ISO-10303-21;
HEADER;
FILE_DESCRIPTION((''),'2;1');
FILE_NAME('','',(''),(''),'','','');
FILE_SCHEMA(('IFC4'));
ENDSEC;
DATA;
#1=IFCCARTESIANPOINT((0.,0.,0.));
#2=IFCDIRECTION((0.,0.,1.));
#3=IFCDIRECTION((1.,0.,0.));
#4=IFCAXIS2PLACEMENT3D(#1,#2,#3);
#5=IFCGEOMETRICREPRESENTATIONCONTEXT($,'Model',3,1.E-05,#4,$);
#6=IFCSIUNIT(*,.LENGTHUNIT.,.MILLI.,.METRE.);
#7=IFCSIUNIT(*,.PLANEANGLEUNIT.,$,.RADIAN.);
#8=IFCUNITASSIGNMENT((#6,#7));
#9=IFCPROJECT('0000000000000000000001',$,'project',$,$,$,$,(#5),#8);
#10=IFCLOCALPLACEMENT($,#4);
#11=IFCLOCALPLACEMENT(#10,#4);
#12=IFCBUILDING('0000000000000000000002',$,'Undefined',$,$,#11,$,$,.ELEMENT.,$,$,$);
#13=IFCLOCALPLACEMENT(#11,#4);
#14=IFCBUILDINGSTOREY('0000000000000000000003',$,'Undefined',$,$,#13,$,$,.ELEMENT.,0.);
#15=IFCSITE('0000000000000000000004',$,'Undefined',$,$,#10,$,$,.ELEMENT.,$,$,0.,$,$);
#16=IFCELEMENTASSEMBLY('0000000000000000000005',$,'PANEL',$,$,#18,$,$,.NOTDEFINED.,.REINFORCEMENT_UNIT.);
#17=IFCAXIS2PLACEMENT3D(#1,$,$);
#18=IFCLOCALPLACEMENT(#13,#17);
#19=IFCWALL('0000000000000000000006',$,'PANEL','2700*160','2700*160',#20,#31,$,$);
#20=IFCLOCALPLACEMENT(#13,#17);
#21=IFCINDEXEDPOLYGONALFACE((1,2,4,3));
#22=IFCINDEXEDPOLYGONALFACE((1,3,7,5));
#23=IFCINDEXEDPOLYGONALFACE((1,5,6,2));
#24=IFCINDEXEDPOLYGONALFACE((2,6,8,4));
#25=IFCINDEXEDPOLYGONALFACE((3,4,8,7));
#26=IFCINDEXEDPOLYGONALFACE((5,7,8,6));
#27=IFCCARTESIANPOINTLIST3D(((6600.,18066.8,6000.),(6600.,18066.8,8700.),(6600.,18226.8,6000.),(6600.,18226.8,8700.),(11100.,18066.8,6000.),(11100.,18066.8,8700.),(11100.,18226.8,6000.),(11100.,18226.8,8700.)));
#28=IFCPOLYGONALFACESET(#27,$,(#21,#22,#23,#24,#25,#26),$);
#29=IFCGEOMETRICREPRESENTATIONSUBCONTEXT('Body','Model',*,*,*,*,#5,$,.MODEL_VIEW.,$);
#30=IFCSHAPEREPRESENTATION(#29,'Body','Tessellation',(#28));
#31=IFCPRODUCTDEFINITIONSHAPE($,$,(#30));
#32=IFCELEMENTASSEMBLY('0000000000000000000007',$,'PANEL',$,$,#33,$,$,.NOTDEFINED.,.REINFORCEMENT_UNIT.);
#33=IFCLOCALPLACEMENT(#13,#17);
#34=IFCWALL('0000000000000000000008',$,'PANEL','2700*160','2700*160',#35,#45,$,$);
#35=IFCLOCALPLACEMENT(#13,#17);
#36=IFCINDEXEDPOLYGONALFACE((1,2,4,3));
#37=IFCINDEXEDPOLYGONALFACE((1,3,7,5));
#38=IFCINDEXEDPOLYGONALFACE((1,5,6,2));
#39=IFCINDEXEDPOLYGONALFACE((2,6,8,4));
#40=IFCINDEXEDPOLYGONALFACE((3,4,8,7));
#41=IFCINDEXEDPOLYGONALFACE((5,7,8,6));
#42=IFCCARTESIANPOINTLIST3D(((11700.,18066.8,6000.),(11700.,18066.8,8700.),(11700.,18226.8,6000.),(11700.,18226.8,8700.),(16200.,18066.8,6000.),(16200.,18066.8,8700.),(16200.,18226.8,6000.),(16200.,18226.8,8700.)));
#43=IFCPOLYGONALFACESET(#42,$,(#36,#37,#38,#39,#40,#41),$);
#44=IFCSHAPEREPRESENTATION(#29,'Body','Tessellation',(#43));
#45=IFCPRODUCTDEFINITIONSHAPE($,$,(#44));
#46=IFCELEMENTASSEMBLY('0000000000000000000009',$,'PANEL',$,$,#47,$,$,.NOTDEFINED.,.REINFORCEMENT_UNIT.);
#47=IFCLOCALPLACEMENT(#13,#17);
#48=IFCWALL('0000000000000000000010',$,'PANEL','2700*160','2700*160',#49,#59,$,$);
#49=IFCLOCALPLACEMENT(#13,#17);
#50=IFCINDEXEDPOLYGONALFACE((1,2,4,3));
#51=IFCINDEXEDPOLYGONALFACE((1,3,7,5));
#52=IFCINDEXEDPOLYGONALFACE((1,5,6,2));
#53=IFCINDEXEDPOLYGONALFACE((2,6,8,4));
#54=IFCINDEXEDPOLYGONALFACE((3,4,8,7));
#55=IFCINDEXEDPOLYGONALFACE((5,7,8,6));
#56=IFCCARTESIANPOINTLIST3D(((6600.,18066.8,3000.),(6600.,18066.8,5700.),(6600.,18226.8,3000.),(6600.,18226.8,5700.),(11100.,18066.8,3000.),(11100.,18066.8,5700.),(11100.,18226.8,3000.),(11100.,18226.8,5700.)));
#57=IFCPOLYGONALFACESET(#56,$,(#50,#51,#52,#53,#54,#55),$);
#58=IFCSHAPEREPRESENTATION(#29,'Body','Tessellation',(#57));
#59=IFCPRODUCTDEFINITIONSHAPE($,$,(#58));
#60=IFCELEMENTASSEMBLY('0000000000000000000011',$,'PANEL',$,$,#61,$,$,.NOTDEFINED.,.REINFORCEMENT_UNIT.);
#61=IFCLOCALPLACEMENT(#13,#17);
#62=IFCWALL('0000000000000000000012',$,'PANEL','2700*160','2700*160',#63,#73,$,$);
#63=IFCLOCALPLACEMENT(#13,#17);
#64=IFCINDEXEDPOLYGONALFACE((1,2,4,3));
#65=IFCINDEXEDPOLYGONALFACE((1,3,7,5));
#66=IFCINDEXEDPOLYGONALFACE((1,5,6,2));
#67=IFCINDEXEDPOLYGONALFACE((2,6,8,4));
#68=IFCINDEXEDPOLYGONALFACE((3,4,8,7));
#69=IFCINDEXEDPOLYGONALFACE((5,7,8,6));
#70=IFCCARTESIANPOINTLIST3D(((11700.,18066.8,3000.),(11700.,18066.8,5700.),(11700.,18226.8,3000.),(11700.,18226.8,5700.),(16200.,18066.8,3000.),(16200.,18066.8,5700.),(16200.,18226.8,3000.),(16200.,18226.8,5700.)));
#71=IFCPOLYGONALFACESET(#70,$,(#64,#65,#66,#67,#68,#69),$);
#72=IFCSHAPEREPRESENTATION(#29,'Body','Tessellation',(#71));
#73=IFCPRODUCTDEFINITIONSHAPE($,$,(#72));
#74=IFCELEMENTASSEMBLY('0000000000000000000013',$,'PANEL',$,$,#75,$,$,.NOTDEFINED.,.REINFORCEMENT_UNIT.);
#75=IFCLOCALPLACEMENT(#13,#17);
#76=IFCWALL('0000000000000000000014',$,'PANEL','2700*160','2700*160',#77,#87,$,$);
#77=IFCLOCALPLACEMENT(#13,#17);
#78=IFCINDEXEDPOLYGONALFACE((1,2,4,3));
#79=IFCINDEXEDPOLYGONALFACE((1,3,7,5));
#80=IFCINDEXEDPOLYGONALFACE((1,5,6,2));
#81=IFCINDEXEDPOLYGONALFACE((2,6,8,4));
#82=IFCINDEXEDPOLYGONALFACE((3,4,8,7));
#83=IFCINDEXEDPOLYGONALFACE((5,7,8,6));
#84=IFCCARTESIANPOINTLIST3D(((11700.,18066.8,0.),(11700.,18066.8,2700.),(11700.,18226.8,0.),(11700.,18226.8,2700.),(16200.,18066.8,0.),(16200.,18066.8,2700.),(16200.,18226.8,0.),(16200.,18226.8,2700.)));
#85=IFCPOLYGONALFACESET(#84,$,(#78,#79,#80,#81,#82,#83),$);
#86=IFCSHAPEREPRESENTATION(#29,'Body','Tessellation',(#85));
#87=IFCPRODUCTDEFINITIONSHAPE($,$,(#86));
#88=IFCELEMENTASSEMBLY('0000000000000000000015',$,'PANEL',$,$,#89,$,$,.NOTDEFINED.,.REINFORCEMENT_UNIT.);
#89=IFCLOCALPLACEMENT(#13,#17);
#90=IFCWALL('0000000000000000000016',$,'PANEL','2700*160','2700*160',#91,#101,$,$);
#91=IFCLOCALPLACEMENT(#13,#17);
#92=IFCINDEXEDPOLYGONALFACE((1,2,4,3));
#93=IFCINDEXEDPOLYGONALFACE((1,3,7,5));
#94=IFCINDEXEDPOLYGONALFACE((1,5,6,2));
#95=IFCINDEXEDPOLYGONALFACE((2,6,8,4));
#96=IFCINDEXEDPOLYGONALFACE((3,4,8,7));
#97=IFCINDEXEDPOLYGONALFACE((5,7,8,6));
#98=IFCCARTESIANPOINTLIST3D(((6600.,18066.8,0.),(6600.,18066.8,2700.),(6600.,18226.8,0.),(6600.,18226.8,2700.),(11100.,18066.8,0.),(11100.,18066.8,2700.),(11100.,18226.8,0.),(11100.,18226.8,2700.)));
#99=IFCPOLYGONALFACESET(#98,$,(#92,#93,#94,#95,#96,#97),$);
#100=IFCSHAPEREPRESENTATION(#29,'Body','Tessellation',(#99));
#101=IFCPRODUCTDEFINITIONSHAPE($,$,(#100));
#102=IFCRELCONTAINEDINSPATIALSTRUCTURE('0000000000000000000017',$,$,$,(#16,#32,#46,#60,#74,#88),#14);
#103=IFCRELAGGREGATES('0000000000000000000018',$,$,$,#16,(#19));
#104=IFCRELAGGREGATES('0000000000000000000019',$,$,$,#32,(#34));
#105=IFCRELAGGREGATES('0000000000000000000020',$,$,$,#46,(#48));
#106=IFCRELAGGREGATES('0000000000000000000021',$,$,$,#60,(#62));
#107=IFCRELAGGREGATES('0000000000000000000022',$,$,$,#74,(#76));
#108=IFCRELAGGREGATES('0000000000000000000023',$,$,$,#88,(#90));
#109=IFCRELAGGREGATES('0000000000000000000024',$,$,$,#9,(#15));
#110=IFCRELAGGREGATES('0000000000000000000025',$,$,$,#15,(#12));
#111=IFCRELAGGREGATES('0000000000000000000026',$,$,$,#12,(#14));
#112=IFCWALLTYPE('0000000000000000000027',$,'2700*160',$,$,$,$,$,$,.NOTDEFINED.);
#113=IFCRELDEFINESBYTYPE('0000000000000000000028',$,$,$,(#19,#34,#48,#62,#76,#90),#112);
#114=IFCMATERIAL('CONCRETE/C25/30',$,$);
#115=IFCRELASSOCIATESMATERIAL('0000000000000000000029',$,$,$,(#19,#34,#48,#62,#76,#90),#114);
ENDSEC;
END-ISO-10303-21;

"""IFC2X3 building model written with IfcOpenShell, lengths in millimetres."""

from ifc_helpers import new_model, si_unit, frame, frame_2d, origin_with_axes, place, context, subcontext, project, spatial, rectangle, extrude, material, type_object, element, aggregate, save


model = new_model("IFC2X3")

# Units and contexts
model_context = context("Model", 3, precision=1e-05, world=origin_with_axes())
body_context = subcontext(model_context, "Body", "Model", "MODEL_VIEW")
ifc_project = project(units=[si_unit("LENGTHUNIT", "METRE", prefix="MILLI"), si_unit("PLANEANGLEUNIT", "RADIAN")], contexts=[model_context])

# Site, building, storey
site_placement = place(None, origin_with_axes())
site = spatial("IfcSite", under=ifc_project, at=site_placement, Name="Undefined", CompositionType="ELEMENT", RefElevation=0.0)
building_placement = place(site_placement, origin_with_axes())
building = spatial("IfcBuilding", under=site, at=building_placement, Name="Undefined", CompositionType="ELEMENT")
storey_placement = place(building_placement, origin_with_axes())
storey = spatial("IfcBuildingStorey", under=building, at=storey_placement, Name="Undefined", CompositionType="ELEMENT", Elevation=0.0)

# Shared definitions
ifc_material = material(Name="CONCRETE/C25/30")

# Element assemblies, walls
assembly_1_placement = place(storey_placement, origin_with_axes())
assembly_1 = element("IfcElementAssembly", 1, at=assembly_1_placement, inside=storey, Name="PANEL", AssemblyPlace="NOTDEFINED", PredefinedType="REINFORCEMENT_UNIT")
wall_type = type_object("IfcWallType", Name="2700*160", PredefinedType="NOTDEFINED")
wall_1_placement = place(assembly_1_placement, frame((6600.0, 18146.8, 6000.0), z_axis=(0.0, 0.0, 1.0), x_axis=(1.0, 0.0, 0.0)))
wall_1 = element("IfcWall", 2, at=wall_1_placement, type_object=wall_type, material=ifc_material, Name="PANEL", Description="2700*160", ObjectType="2700*160", context=body_context, shape_type="SweptSolid", body=[
    extrude(rectangle(XDim=4500.0, YDim=160.0, at=frame_2d((0.0, 2250.0), x_axis=(0.0, -1.0))), frame((0.0, 0.0, 0.0), z_axis=(0.0, 0.0, 1.0), x_axis=(0.0, -1.0, 0.0)), (0.0, 0.0, 1.0), 2700.0),
])
aggregate(assembly_1, [wall_1])
assembly_2_placement = place(storey_placement, origin_with_axes())
assembly_2 = element("IfcElementAssembly", 3, at=assembly_2_placement, inside=storey, Name="PANEL", AssemblyPlace="NOTDEFINED", PredefinedType="REINFORCEMENT_UNIT")
wall_2_placement = place(assembly_2_placement, frame((11700.0, 18146.8, 6000.0), z_axis=(0.0, 0.0, 1.0), x_axis=(1.0, 0.0, 0.0)))
wall_2 = element("IfcWall", 4, at=wall_2_placement, type_object=wall_type, material=ifc_material, Name="PANEL", Description="2700*160", ObjectType="2700*160", context=body_context, shape_type="SweptSolid", body=[
    extrude(rectangle(XDim=4500.0, YDim=160.0, at=frame_2d((0.0, 2250.0), x_axis=(0.0, -1.0))), frame((0.0, 0.0, 0.0), z_axis=(0.0, 0.0, 1.0), x_axis=(0.0, -1.0, 0.0)), (0.0, 0.0, 1.0), 2700.0),
])
aggregate(assembly_2, [wall_2])
assembly_3_placement = place(storey_placement, origin_with_axes())
assembly_3 = element("IfcElementAssembly", 5, at=assembly_3_placement, inside=storey, Name="PANEL", AssemblyPlace="NOTDEFINED", PredefinedType="REINFORCEMENT_UNIT")
wall_3_placement = place(assembly_3_placement, frame((6600.0, 18146.8, 3000.0), z_axis=(0.0, 0.0, 1.0), x_axis=(1.0, 0.0, 0.0)))
wall_3 = element("IfcWall", 6, at=wall_3_placement, type_object=wall_type, material=ifc_material, Name="PANEL", Description="2700*160", ObjectType="2700*160", context=body_context, shape_type="SweptSolid", body=[
    extrude(rectangle(XDim=4500.0, YDim=160.0, at=frame_2d((0.0, 2250.0), x_axis=(0.0, -1.0))), frame((0.0, 0.0, 0.0), z_axis=(0.0, 0.0, 1.0), x_axis=(0.0, -1.0, 0.0)), (0.0, 0.0, 1.0), 2700.0),
])
aggregate(assembly_3, [wall_3])
assembly_4_placement = place(storey_placement, origin_with_axes())
assembly_4 = element("IfcElementAssembly", 7, at=assembly_4_placement, inside=storey, Name="PANEL", AssemblyPlace="NOTDEFINED", PredefinedType="REINFORCEMENT_UNIT")
wall_4_placement = place(assembly_4_placement, frame((11700.0, 18146.8, 3000.0), z_axis=(0.0, 0.0, 1.0), x_axis=(1.0, 0.0, 0.0)))
wall_4 = element("IfcWall", 8, at=wall_4_placement, type_object=wall_type, material=ifc_material, Name="PANEL", Description="2700*160", ObjectType="2700*160", context=body_context, shape_type="SweptSolid", body=[
    extrude(rectangle(XDim=4500.0, YDim=160.0, at=frame_2d((0.0, 2250.0), x_axis=(0.0, -1.0))), frame((0.0, 0.0, 0.0), z_axis=(0.0, 0.0, 1.0), x_axis=(0.0, -1.0, 0.0)), (0.0, 0.0, 1.0), 2700.0),
])
aggregate(assembly_4, [wall_4])
assembly_5_placement = place(storey_placement, origin_with_axes())
assembly_5 = element("IfcElementAssembly", 9, at=assembly_5_placement, inside=storey, Name="PANEL", AssemblyPlace="NOTDEFINED", PredefinedType="REINFORCEMENT_UNIT")
wall_5_placement = place(assembly_5_placement, frame((16200.0, 18146.8, 0.0), z_axis=(0.0, 0.0, 1.0), x_axis=(-1.0, 0.0, 0.0)))
wall_5 = element("IfcWall", 10, at=wall_5_placement, type_object=wall_type, material=ifc_material, Name="PANEL", Description="2700*160", ObjectType="2700*160", context=body_context, shape_type="SweptSolid", body=[
    extrude(rectangle(XDim=4500.0, YDim=160.0, at=frame_2d((0.0, 2250.0), x_axis=(0.0, -1.0))), frame((0.0, 0.0, 0.0), z_axis=(0.0, 0.0, 1.0), x_axis=(0.0, -1.0, 0.0)), (0.0, 0.0, 1.0), 2700.0),
])
aggregate(assembly_5, [wall_5])
assembly_6_placement = place(storey_placement, origin_with_axes())
assembly_6 = element("IfcElementAssembly", 11, at=assembly_6_placement, inside=storey, Name="PANEL", AssemblyPlace="NOTDEFINED", PredefinedType="REINFORCEMENT_UNIT")
wall_6_placement = place(assembly_6_placement, frame((6600.0, 18146.8, 0.0), z_axis=(0.0, 0.0, 1.0), x_axis=(1.0, 0.0, 0.0)))
wall_6 = element("IfcWall", 12, at=wall_6_placement, type_object=wall_type, material=ifc_material, Name="PANEL", Description="2700*160", ObjectType="2700*160", context=body_context, shape_type="SweptSolid", body=[
    extrude(rectangle(XDim=4500.0, YDim=160.0, at=frame_2d((0.0, 2250.0), x_axis=(0.0, -1.0))), frame((0.0, 0.0, 0.0), z_axis=(0.0, 0.0, 1.0), x_axis=(0.0, -1.0, 0.0)), (0.0, 0.0, 1.0), 2700.0),
])
aggregate(assembly_6, [wall_6])

save(model, "model.ifc")
